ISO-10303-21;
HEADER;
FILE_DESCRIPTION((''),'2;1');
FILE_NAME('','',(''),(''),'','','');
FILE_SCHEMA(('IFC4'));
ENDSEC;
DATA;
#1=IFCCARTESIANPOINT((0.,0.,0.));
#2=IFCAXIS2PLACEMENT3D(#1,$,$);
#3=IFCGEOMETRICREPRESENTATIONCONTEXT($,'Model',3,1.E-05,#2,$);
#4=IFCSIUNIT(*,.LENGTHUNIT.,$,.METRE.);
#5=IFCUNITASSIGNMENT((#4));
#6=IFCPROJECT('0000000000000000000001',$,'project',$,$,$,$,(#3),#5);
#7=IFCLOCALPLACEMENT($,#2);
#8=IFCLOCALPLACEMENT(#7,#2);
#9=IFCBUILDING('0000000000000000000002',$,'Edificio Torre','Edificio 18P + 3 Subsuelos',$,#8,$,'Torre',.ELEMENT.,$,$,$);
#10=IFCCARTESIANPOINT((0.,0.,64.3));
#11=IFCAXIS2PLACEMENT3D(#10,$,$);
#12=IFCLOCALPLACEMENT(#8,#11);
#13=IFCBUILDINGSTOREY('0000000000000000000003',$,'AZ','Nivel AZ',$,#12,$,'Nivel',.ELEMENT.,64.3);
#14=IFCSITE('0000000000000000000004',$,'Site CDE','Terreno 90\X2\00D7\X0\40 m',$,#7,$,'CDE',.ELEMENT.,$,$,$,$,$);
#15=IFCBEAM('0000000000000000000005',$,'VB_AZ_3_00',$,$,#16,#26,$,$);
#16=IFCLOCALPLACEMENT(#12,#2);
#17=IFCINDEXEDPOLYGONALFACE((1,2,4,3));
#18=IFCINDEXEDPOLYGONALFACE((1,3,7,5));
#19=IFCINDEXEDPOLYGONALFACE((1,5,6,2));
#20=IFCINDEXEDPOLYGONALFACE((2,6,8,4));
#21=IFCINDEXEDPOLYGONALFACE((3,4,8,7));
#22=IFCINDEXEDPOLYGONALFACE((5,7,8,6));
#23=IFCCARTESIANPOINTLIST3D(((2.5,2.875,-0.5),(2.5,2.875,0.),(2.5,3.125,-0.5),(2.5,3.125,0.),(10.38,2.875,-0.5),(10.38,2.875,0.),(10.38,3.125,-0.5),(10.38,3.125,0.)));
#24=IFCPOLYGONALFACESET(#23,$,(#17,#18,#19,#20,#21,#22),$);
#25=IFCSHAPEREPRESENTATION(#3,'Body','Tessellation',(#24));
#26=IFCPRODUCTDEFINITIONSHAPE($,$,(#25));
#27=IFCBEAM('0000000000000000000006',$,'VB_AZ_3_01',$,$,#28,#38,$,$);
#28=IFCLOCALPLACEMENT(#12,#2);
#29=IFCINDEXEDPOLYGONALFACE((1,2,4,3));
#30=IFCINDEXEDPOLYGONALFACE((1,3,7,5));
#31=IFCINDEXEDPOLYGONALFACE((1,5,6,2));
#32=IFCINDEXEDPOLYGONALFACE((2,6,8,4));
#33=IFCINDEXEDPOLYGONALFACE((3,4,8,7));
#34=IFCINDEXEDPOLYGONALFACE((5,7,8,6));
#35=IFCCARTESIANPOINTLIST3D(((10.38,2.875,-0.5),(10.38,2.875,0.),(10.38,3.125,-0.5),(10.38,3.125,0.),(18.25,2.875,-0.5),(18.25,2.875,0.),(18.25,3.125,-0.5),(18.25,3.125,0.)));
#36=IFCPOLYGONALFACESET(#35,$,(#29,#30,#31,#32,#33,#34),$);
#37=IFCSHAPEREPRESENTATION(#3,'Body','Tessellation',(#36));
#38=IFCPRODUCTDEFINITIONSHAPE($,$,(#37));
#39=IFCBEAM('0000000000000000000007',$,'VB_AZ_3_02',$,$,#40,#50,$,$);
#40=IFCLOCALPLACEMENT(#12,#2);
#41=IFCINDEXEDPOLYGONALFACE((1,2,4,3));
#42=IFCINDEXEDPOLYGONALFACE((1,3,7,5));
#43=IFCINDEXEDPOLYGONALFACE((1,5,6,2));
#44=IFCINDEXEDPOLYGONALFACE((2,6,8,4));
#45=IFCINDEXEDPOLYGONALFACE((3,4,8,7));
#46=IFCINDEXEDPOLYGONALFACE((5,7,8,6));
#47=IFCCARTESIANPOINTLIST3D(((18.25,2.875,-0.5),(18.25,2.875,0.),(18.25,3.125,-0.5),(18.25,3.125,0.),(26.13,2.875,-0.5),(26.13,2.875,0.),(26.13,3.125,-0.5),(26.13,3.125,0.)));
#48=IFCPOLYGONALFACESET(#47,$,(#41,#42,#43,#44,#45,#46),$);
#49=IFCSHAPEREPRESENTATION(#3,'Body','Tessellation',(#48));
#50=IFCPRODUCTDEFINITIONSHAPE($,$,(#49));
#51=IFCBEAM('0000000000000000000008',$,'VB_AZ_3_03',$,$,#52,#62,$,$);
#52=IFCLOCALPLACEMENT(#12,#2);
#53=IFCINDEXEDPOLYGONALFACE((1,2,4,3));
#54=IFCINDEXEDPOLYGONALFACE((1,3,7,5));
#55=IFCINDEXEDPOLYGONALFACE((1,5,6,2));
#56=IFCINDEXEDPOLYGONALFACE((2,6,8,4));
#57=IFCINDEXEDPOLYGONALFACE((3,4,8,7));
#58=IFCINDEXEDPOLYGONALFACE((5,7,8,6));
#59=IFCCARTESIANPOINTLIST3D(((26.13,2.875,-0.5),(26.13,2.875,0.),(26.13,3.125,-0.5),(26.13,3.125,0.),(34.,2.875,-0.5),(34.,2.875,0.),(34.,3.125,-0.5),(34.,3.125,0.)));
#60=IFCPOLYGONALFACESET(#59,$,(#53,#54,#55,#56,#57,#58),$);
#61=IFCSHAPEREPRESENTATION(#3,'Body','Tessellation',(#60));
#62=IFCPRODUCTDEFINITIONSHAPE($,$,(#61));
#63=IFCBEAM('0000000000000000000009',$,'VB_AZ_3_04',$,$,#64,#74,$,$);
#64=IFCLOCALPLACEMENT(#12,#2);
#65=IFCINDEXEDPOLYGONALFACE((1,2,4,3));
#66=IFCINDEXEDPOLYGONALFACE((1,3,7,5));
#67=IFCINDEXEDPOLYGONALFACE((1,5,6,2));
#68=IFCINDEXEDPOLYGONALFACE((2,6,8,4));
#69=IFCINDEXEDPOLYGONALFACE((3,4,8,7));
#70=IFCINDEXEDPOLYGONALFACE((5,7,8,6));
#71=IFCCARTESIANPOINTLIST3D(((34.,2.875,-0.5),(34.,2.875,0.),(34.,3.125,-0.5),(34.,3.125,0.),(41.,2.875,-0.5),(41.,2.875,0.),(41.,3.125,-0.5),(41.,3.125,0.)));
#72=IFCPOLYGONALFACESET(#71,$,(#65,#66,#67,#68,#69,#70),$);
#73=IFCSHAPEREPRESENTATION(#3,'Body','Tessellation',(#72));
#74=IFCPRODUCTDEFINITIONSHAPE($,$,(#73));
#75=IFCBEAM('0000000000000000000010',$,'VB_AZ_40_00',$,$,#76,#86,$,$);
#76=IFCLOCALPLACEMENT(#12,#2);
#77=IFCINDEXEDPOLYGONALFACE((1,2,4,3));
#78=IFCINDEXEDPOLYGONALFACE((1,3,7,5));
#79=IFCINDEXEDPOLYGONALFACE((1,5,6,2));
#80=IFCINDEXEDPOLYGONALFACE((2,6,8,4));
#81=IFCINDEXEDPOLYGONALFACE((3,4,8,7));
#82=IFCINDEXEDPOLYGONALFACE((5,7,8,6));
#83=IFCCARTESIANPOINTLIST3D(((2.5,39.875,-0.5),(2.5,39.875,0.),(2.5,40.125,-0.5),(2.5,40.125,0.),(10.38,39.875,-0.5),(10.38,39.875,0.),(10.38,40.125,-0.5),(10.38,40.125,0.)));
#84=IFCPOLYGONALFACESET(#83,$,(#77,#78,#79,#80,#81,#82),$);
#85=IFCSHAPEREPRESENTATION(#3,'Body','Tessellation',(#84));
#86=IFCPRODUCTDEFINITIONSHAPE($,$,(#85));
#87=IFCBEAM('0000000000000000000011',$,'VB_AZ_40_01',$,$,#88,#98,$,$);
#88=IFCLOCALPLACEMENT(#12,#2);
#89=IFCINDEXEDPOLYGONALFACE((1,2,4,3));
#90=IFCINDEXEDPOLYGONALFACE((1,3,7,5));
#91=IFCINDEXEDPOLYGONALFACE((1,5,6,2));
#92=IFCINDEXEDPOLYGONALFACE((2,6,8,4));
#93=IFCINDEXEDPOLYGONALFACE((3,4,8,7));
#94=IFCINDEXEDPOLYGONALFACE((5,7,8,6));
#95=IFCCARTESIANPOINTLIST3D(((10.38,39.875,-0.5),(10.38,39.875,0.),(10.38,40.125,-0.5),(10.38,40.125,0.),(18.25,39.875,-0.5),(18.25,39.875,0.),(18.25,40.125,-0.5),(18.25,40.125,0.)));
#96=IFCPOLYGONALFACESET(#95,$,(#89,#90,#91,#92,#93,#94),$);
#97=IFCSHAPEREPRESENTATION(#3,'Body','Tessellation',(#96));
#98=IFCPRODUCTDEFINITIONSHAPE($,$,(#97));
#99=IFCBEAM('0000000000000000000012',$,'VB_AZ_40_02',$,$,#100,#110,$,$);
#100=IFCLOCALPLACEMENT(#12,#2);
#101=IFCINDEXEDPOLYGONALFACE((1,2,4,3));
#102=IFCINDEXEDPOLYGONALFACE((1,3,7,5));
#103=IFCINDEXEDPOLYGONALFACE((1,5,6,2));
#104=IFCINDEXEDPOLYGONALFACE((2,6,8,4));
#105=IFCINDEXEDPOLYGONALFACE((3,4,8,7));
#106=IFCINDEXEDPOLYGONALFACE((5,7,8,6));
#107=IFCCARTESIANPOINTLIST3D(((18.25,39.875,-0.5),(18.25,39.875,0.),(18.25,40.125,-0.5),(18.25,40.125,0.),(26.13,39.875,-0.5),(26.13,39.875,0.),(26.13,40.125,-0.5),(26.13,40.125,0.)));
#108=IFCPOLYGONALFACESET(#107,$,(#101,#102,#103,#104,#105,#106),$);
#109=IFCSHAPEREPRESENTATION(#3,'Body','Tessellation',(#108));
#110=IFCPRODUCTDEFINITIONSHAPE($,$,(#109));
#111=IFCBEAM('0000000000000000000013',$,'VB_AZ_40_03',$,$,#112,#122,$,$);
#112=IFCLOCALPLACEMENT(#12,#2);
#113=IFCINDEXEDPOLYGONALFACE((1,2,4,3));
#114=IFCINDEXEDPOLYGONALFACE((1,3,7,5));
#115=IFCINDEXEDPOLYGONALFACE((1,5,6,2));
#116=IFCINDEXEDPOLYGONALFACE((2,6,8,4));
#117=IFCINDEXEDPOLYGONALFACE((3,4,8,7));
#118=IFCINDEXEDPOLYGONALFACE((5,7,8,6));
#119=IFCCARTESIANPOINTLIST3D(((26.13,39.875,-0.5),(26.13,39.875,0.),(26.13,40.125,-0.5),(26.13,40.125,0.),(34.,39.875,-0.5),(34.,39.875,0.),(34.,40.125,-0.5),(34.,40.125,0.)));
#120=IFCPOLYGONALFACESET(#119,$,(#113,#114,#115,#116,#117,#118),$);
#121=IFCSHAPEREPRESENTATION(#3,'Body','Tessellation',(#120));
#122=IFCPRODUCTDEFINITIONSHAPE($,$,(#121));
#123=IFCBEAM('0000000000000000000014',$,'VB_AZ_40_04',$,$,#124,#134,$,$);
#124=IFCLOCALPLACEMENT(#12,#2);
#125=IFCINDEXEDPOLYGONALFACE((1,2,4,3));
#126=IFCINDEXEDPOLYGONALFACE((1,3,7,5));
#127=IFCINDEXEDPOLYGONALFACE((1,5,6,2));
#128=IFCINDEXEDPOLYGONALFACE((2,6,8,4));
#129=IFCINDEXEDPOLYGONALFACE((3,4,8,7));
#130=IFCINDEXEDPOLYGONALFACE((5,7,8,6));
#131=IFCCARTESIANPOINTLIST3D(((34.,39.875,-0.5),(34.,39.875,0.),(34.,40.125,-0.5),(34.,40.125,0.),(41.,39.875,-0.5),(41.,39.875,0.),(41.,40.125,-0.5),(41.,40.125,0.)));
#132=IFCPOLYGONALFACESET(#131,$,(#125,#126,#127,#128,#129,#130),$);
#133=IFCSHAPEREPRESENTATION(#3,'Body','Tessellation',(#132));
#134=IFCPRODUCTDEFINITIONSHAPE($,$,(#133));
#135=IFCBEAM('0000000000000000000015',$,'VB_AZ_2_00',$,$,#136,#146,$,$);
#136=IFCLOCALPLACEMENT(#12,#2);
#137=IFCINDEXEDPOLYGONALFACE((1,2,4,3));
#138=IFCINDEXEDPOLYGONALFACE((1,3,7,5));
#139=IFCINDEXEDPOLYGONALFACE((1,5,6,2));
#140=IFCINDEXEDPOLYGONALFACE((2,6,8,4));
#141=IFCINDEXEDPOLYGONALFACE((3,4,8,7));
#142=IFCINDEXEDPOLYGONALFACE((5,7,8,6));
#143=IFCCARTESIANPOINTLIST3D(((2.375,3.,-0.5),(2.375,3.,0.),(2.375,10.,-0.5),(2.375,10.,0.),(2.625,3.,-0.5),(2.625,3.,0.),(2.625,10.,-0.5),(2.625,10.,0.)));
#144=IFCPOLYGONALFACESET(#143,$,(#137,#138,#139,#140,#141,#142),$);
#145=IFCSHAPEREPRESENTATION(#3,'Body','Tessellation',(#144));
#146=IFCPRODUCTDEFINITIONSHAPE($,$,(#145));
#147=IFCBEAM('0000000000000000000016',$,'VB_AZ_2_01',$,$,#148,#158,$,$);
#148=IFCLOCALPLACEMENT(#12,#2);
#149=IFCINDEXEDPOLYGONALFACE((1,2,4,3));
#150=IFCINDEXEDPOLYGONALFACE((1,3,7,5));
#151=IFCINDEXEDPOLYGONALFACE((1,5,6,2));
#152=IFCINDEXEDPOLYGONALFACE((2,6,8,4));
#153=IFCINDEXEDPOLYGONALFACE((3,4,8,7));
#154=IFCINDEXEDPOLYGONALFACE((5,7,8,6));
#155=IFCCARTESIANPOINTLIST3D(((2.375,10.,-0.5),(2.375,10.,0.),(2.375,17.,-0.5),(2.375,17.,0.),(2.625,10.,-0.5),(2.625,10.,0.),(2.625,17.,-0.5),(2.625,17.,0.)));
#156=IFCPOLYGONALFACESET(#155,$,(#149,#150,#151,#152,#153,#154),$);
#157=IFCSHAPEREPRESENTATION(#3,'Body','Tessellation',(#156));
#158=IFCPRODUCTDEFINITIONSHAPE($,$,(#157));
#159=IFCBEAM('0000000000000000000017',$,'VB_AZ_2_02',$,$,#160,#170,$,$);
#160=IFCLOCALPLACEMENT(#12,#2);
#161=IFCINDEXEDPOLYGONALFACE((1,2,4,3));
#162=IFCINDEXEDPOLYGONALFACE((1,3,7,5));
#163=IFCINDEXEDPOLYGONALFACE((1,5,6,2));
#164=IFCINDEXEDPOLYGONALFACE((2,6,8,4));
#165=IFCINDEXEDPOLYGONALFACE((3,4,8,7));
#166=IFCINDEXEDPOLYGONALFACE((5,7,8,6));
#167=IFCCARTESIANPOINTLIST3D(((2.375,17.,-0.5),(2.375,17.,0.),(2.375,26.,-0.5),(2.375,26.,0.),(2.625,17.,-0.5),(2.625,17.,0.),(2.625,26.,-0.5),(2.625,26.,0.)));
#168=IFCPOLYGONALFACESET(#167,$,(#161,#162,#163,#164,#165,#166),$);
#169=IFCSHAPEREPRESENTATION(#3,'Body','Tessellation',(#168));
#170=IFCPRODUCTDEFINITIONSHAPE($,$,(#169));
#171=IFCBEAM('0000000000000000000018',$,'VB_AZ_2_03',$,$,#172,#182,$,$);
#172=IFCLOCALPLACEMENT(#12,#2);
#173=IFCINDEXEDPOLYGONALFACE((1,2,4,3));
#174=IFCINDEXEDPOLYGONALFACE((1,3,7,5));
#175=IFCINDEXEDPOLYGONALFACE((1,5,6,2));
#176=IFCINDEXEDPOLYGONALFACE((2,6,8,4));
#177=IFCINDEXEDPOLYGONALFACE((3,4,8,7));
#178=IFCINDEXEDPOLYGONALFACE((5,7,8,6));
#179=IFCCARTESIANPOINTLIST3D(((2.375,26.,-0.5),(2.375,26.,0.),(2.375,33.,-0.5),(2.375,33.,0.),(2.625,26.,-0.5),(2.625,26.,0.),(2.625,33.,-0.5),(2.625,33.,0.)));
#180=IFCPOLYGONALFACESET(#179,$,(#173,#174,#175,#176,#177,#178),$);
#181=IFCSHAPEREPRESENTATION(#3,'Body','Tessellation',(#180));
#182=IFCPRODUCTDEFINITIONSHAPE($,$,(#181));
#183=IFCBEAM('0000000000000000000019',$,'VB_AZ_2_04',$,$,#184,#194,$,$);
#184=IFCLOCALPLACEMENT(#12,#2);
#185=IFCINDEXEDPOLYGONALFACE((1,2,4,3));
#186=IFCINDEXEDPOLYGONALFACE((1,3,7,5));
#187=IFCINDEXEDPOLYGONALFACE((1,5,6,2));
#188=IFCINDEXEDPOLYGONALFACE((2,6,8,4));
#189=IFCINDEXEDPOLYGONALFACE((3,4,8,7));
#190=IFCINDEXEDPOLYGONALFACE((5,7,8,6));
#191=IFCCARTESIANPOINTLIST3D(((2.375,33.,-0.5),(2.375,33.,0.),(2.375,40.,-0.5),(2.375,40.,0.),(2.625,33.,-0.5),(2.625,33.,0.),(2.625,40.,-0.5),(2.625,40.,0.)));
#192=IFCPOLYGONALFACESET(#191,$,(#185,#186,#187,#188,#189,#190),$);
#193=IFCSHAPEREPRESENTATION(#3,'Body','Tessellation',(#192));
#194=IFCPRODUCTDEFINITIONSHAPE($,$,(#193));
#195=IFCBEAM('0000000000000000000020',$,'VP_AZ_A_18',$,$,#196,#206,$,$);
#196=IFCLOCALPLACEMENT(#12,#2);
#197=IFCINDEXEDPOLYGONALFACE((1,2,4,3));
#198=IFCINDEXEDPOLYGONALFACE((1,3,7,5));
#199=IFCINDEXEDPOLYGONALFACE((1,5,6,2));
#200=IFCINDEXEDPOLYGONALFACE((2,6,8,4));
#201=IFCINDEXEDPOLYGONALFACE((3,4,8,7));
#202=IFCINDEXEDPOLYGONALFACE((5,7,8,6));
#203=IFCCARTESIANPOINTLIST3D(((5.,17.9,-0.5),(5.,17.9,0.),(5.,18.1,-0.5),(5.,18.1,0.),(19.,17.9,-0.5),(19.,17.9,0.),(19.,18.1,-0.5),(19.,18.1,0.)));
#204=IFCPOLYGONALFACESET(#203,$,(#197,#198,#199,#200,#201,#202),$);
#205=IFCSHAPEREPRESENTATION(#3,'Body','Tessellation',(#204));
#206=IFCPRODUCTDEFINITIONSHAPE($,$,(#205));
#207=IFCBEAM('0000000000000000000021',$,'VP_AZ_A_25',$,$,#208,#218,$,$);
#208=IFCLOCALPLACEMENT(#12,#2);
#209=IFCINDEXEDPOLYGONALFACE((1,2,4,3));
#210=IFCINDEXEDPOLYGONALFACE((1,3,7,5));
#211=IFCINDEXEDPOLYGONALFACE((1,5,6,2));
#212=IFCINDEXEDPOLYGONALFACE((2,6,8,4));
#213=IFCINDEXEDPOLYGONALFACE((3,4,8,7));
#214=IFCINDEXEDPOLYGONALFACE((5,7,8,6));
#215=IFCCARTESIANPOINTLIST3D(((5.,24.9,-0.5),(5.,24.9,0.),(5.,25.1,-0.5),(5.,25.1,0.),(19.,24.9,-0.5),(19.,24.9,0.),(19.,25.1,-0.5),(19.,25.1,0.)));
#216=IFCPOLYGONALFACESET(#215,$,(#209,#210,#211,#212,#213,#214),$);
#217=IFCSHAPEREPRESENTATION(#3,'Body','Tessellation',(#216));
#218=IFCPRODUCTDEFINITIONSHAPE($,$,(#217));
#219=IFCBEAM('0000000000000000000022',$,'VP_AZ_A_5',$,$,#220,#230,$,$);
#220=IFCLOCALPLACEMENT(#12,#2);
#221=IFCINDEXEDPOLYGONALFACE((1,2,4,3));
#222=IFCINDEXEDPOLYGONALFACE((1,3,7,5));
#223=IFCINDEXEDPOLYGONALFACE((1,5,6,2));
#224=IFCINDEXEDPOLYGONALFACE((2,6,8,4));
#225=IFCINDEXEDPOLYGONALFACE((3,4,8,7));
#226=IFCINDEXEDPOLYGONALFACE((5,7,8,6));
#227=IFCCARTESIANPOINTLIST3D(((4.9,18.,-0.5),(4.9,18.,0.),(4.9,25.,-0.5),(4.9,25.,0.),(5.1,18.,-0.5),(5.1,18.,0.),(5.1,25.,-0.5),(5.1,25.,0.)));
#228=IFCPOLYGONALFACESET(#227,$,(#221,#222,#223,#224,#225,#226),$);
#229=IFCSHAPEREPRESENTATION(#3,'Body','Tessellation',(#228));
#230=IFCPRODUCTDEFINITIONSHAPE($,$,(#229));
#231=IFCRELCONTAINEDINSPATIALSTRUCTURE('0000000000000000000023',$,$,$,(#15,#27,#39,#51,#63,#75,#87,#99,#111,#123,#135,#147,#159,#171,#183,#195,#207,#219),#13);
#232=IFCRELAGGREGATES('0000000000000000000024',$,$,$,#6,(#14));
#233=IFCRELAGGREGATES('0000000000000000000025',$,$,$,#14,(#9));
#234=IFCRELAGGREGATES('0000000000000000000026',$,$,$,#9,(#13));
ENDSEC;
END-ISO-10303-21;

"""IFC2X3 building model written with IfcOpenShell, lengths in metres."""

from ifc_helpers import new_model, si_unit, frame, origin, origin_2d, place, context, project, spatial, rectangle, extrude, element, save


model = new_model("IFC2X3")

# Units and contexts
model_context = context("Model", 3, precision=1e-05, world=origin())
ifc_project = project(units=[si_unit("LENGTHUNIT", "METRE")], contexts=[model_context])

# Site, building, storey
site_placement = place(None, origin())
site = spatial("IfcSite", under=ifc_project, at=site_placement, Name="Site CDE", Description="Terreno 90×40 m", LongName="CDE", CompositionType="ELEMENT")
building_placement = place(site_placement, origin())
building = spatial("IfcBuilding", under=site, at=building_placement, Name="Edificio Torre", Description="Edificio 18P + 3 Subsuelos", LongName="Torre", CompositionType="ELEMENT")
storey_placement = place(building_placement, frame((0.0, 0.0, 64.3)))
storey = spatial("IfcBuildingStorey", under=building, at=storey_placement, Name="AZ", Description="Nivel AZ", LongName="Nivel", CompositionType="ELEMENT", Elevation=64.3)

# Beams
beam_1_placement = place(storey_placement, frame((6.44, 3.0, -0.5)))
element("IfcBeam", 1, at=beam_1_placement, inside=storey, Name="VB_AZ_3_00", context=model_context, shape_type="SweptSolid", body=[
    extrude(rectangle(XDim=7.88, YDim=0.25, at=origin_2d()), origin(), (0.0, 0.0, 1.0), 0.5),
])
beam_2_placement = place(storey_placement, frame((14.315, 3.0, -0.5)))
element("IfcBeam", 2, at=beam_2_placement, inside=storey, Name="VB_AZ_3_01", context=model_context, shape_type="SweptSolid", body=[
    extrude(rectangle(XDim=7.87, YDim=0.25, at=origin_2d()), origin(), (0.0, 0.0, 1.0), 0.5),
])
beam_3_placement = place(storey_placement, frame((22.19, 3.0, -0.5)))
element("IfcBeam", 3, at=beam_3_placement, inside=storey, Name="VB_AZ_3_02", context=model_context, shape_type="SweptSolid", body=[
    extrude(rectangle(XDim=7.88, YDim=0.25, at=origin_2d()), origin(), (0.0, 0.0, 1.0), 0.5),
])
beam_4_placement = place(storey_placement, frame((30.065, 3.0, -0.5)))
element("IfcBeam", 4, at=beam_4_placement, inside=storey, Name="VB_AZ_3_03", context=model_context, shape_type="SweptSolid", body=[
    extrude(rectangle(XDim=7.87, YDim=0.25, at=origin_2d()), origin(), (0.0, 0.0, 1.0), 0.5),
])
beam_5_placement = place(storey_placement, frame((37.5, 3.0, -0.5)))
element("IfcBeam", 5, at=beam_5_placement, inside=storey, Name="VB_AZ_3_04", context=model_context, shape_type="SweptSolid", body=[
    extrude(rectangle(XDim=7.0, YDim=0.25, at=origin_2d()), origin(), (0.0, 0.0, 1.0), 0.5),
])
beam_6_placement = place(storey_placement, frame((6.44, 40.0, -0.5)))
element("IfcBeam", 6, at=beam_6_placement, inside=storey, Name="VB_AZ_40_00", context=model_context, shape_type="SweptSolid", body=[
    extrude(rectangle(XDim=7.88, YDim=0.25, at=origin_2d()), origin(), (0.0, 0.0, 1.0), 0.5),
])
beam_7_placement = place(storey_placement, frame((14.315, 40.0, -0.5)))
element("IfcBeam", 7, at=beam_7_placement, inside=storey, Name="VB_AZ_40_01", context=model_context, shape_type="SweptSolid", body=[
    extrude(rectangle(XDim=7.87, YDim=0.25, at=origin_2d()), origin(), (0.0, 0.0, 1.0), 0.5),
])
beam_8_placement = place(storey_placement, frame((22.19, 40.0, -0.5)))
element("IfcBeam", 8, at=beam_8_placement, inside=storey, Name="VB_AZ_40_02", context=model_context, shape_type="SweptSolid", body=[
    extrude(rectangle(XDim=7.88, YDim=0.25, at=origin_2d()), origin(), (0.0, 0.0, 1.0), 0.5),
])
beam_9_placement = place(storey_placement, frame((30.065, 40.0, -0.5)))
element("IfcBeam", 9, at=beam_9_placement, inside=storey, Name="VB_AZ_40_03", context=model_context, shape_type="SweptSolid", body=[
    extrude(rectangle(XDim=7.87, YDim=0.25, at=origin_2d()), origin(), (0.0, 0.0, 1.0), 0.5),
])
beam_10_placement = place(storey_placement, frame((37.5, 40.0, -0.5)))
element("IfcBeam", 10, at=beam_10_placement, inside=storey, Name="VB_AZ_40_04", context=model_context, shape_type="SweptSolid", body=[
    extrude(rectangle(XDim=7.0, YDim=0.25, at=origin_2d()), origin(), (0.0, 0.0, 1.0), 0.5),
])
for number, where, name in (
    (11, (2.5, 6.5, -0.5), "VB_AZ_2_00"),
    (12, (2.5, 13.5, -0.5), "VB_AZ_2_01"),
):
    element("IfcBeam", number, at=place(storey_placement, frame(where)), inside=storey, Name=name, context=model_context, shape_type="SweptSolid", body=[
        extrude(rectangle(XDim=0.25, YDim=7.0, at=origin_2d()), origin(), (0.0, 0.0, 1.0), 0.5),
    ])
beam_11_placement = place(storey_placement, frame((2.5, 21.5, -0.5)))
element("IfcBeam", 13, at=beam_11_placement, inside=storey, Name="VB_AZ_2_02", context=model_context, shape_type="SweptSolid", body=[
    extrude(rectangle(XDim=0.25, YDim=9.0, at=origin_2d()), origin(), (0.0, 0.0, 1.0), 0.5),
])
for number, where, name in (
    (14, (2.5, 29.5, -0.5), "VB_AZ_2_03"),
    (15, (2.5, 36.5, -0.5), "VB_AZ_2_04"),
):
    element("IfcBeam", number, at=place(storey_placement, frame(where)), inside=storey, Name=name, context=model_context, shape_type="SweptSolid", body=[
        extrude(rectangle(XDim=0.25, YDim=7.0, at=origin_2d()), origin(), (0.0, 0.0, 1.0), 0.5),
    ])
for number, where, name in (
    (16, (12.0, 18.0, -0.5), "VP_AZ_A_18"),
    (17, (12.0, 25.0, -0.5), "VP_AZ_A_25"),
):
    element("IfcBeam", number, at=place(storey_placement, frame(where)), inside=storey, Name=name, context=model_context, shape_type="SweptSolid", body=[
        extrude(rectangle(XDim=14.0, YDim=0.2, at=origin_2d()), origin(), (0.0, 0.0, 1.0), 0.5),
    ])
beam_12_placement = place(storey_placement, frame((5.0, 21.5, -0.5)))
element("IfcBeam", 18, at=beam_12_placement, inside=storey, Name="VP_AZ_A_5", context=model_context, shape_type="SweptSolid", body=[
    extrude(rectangle(XDim=0.2, YDim=7.0, at=origin_2d()), origin(), (0.0, 0.0, 1.0), 0.5),
])

save(model, "model.ifc")
